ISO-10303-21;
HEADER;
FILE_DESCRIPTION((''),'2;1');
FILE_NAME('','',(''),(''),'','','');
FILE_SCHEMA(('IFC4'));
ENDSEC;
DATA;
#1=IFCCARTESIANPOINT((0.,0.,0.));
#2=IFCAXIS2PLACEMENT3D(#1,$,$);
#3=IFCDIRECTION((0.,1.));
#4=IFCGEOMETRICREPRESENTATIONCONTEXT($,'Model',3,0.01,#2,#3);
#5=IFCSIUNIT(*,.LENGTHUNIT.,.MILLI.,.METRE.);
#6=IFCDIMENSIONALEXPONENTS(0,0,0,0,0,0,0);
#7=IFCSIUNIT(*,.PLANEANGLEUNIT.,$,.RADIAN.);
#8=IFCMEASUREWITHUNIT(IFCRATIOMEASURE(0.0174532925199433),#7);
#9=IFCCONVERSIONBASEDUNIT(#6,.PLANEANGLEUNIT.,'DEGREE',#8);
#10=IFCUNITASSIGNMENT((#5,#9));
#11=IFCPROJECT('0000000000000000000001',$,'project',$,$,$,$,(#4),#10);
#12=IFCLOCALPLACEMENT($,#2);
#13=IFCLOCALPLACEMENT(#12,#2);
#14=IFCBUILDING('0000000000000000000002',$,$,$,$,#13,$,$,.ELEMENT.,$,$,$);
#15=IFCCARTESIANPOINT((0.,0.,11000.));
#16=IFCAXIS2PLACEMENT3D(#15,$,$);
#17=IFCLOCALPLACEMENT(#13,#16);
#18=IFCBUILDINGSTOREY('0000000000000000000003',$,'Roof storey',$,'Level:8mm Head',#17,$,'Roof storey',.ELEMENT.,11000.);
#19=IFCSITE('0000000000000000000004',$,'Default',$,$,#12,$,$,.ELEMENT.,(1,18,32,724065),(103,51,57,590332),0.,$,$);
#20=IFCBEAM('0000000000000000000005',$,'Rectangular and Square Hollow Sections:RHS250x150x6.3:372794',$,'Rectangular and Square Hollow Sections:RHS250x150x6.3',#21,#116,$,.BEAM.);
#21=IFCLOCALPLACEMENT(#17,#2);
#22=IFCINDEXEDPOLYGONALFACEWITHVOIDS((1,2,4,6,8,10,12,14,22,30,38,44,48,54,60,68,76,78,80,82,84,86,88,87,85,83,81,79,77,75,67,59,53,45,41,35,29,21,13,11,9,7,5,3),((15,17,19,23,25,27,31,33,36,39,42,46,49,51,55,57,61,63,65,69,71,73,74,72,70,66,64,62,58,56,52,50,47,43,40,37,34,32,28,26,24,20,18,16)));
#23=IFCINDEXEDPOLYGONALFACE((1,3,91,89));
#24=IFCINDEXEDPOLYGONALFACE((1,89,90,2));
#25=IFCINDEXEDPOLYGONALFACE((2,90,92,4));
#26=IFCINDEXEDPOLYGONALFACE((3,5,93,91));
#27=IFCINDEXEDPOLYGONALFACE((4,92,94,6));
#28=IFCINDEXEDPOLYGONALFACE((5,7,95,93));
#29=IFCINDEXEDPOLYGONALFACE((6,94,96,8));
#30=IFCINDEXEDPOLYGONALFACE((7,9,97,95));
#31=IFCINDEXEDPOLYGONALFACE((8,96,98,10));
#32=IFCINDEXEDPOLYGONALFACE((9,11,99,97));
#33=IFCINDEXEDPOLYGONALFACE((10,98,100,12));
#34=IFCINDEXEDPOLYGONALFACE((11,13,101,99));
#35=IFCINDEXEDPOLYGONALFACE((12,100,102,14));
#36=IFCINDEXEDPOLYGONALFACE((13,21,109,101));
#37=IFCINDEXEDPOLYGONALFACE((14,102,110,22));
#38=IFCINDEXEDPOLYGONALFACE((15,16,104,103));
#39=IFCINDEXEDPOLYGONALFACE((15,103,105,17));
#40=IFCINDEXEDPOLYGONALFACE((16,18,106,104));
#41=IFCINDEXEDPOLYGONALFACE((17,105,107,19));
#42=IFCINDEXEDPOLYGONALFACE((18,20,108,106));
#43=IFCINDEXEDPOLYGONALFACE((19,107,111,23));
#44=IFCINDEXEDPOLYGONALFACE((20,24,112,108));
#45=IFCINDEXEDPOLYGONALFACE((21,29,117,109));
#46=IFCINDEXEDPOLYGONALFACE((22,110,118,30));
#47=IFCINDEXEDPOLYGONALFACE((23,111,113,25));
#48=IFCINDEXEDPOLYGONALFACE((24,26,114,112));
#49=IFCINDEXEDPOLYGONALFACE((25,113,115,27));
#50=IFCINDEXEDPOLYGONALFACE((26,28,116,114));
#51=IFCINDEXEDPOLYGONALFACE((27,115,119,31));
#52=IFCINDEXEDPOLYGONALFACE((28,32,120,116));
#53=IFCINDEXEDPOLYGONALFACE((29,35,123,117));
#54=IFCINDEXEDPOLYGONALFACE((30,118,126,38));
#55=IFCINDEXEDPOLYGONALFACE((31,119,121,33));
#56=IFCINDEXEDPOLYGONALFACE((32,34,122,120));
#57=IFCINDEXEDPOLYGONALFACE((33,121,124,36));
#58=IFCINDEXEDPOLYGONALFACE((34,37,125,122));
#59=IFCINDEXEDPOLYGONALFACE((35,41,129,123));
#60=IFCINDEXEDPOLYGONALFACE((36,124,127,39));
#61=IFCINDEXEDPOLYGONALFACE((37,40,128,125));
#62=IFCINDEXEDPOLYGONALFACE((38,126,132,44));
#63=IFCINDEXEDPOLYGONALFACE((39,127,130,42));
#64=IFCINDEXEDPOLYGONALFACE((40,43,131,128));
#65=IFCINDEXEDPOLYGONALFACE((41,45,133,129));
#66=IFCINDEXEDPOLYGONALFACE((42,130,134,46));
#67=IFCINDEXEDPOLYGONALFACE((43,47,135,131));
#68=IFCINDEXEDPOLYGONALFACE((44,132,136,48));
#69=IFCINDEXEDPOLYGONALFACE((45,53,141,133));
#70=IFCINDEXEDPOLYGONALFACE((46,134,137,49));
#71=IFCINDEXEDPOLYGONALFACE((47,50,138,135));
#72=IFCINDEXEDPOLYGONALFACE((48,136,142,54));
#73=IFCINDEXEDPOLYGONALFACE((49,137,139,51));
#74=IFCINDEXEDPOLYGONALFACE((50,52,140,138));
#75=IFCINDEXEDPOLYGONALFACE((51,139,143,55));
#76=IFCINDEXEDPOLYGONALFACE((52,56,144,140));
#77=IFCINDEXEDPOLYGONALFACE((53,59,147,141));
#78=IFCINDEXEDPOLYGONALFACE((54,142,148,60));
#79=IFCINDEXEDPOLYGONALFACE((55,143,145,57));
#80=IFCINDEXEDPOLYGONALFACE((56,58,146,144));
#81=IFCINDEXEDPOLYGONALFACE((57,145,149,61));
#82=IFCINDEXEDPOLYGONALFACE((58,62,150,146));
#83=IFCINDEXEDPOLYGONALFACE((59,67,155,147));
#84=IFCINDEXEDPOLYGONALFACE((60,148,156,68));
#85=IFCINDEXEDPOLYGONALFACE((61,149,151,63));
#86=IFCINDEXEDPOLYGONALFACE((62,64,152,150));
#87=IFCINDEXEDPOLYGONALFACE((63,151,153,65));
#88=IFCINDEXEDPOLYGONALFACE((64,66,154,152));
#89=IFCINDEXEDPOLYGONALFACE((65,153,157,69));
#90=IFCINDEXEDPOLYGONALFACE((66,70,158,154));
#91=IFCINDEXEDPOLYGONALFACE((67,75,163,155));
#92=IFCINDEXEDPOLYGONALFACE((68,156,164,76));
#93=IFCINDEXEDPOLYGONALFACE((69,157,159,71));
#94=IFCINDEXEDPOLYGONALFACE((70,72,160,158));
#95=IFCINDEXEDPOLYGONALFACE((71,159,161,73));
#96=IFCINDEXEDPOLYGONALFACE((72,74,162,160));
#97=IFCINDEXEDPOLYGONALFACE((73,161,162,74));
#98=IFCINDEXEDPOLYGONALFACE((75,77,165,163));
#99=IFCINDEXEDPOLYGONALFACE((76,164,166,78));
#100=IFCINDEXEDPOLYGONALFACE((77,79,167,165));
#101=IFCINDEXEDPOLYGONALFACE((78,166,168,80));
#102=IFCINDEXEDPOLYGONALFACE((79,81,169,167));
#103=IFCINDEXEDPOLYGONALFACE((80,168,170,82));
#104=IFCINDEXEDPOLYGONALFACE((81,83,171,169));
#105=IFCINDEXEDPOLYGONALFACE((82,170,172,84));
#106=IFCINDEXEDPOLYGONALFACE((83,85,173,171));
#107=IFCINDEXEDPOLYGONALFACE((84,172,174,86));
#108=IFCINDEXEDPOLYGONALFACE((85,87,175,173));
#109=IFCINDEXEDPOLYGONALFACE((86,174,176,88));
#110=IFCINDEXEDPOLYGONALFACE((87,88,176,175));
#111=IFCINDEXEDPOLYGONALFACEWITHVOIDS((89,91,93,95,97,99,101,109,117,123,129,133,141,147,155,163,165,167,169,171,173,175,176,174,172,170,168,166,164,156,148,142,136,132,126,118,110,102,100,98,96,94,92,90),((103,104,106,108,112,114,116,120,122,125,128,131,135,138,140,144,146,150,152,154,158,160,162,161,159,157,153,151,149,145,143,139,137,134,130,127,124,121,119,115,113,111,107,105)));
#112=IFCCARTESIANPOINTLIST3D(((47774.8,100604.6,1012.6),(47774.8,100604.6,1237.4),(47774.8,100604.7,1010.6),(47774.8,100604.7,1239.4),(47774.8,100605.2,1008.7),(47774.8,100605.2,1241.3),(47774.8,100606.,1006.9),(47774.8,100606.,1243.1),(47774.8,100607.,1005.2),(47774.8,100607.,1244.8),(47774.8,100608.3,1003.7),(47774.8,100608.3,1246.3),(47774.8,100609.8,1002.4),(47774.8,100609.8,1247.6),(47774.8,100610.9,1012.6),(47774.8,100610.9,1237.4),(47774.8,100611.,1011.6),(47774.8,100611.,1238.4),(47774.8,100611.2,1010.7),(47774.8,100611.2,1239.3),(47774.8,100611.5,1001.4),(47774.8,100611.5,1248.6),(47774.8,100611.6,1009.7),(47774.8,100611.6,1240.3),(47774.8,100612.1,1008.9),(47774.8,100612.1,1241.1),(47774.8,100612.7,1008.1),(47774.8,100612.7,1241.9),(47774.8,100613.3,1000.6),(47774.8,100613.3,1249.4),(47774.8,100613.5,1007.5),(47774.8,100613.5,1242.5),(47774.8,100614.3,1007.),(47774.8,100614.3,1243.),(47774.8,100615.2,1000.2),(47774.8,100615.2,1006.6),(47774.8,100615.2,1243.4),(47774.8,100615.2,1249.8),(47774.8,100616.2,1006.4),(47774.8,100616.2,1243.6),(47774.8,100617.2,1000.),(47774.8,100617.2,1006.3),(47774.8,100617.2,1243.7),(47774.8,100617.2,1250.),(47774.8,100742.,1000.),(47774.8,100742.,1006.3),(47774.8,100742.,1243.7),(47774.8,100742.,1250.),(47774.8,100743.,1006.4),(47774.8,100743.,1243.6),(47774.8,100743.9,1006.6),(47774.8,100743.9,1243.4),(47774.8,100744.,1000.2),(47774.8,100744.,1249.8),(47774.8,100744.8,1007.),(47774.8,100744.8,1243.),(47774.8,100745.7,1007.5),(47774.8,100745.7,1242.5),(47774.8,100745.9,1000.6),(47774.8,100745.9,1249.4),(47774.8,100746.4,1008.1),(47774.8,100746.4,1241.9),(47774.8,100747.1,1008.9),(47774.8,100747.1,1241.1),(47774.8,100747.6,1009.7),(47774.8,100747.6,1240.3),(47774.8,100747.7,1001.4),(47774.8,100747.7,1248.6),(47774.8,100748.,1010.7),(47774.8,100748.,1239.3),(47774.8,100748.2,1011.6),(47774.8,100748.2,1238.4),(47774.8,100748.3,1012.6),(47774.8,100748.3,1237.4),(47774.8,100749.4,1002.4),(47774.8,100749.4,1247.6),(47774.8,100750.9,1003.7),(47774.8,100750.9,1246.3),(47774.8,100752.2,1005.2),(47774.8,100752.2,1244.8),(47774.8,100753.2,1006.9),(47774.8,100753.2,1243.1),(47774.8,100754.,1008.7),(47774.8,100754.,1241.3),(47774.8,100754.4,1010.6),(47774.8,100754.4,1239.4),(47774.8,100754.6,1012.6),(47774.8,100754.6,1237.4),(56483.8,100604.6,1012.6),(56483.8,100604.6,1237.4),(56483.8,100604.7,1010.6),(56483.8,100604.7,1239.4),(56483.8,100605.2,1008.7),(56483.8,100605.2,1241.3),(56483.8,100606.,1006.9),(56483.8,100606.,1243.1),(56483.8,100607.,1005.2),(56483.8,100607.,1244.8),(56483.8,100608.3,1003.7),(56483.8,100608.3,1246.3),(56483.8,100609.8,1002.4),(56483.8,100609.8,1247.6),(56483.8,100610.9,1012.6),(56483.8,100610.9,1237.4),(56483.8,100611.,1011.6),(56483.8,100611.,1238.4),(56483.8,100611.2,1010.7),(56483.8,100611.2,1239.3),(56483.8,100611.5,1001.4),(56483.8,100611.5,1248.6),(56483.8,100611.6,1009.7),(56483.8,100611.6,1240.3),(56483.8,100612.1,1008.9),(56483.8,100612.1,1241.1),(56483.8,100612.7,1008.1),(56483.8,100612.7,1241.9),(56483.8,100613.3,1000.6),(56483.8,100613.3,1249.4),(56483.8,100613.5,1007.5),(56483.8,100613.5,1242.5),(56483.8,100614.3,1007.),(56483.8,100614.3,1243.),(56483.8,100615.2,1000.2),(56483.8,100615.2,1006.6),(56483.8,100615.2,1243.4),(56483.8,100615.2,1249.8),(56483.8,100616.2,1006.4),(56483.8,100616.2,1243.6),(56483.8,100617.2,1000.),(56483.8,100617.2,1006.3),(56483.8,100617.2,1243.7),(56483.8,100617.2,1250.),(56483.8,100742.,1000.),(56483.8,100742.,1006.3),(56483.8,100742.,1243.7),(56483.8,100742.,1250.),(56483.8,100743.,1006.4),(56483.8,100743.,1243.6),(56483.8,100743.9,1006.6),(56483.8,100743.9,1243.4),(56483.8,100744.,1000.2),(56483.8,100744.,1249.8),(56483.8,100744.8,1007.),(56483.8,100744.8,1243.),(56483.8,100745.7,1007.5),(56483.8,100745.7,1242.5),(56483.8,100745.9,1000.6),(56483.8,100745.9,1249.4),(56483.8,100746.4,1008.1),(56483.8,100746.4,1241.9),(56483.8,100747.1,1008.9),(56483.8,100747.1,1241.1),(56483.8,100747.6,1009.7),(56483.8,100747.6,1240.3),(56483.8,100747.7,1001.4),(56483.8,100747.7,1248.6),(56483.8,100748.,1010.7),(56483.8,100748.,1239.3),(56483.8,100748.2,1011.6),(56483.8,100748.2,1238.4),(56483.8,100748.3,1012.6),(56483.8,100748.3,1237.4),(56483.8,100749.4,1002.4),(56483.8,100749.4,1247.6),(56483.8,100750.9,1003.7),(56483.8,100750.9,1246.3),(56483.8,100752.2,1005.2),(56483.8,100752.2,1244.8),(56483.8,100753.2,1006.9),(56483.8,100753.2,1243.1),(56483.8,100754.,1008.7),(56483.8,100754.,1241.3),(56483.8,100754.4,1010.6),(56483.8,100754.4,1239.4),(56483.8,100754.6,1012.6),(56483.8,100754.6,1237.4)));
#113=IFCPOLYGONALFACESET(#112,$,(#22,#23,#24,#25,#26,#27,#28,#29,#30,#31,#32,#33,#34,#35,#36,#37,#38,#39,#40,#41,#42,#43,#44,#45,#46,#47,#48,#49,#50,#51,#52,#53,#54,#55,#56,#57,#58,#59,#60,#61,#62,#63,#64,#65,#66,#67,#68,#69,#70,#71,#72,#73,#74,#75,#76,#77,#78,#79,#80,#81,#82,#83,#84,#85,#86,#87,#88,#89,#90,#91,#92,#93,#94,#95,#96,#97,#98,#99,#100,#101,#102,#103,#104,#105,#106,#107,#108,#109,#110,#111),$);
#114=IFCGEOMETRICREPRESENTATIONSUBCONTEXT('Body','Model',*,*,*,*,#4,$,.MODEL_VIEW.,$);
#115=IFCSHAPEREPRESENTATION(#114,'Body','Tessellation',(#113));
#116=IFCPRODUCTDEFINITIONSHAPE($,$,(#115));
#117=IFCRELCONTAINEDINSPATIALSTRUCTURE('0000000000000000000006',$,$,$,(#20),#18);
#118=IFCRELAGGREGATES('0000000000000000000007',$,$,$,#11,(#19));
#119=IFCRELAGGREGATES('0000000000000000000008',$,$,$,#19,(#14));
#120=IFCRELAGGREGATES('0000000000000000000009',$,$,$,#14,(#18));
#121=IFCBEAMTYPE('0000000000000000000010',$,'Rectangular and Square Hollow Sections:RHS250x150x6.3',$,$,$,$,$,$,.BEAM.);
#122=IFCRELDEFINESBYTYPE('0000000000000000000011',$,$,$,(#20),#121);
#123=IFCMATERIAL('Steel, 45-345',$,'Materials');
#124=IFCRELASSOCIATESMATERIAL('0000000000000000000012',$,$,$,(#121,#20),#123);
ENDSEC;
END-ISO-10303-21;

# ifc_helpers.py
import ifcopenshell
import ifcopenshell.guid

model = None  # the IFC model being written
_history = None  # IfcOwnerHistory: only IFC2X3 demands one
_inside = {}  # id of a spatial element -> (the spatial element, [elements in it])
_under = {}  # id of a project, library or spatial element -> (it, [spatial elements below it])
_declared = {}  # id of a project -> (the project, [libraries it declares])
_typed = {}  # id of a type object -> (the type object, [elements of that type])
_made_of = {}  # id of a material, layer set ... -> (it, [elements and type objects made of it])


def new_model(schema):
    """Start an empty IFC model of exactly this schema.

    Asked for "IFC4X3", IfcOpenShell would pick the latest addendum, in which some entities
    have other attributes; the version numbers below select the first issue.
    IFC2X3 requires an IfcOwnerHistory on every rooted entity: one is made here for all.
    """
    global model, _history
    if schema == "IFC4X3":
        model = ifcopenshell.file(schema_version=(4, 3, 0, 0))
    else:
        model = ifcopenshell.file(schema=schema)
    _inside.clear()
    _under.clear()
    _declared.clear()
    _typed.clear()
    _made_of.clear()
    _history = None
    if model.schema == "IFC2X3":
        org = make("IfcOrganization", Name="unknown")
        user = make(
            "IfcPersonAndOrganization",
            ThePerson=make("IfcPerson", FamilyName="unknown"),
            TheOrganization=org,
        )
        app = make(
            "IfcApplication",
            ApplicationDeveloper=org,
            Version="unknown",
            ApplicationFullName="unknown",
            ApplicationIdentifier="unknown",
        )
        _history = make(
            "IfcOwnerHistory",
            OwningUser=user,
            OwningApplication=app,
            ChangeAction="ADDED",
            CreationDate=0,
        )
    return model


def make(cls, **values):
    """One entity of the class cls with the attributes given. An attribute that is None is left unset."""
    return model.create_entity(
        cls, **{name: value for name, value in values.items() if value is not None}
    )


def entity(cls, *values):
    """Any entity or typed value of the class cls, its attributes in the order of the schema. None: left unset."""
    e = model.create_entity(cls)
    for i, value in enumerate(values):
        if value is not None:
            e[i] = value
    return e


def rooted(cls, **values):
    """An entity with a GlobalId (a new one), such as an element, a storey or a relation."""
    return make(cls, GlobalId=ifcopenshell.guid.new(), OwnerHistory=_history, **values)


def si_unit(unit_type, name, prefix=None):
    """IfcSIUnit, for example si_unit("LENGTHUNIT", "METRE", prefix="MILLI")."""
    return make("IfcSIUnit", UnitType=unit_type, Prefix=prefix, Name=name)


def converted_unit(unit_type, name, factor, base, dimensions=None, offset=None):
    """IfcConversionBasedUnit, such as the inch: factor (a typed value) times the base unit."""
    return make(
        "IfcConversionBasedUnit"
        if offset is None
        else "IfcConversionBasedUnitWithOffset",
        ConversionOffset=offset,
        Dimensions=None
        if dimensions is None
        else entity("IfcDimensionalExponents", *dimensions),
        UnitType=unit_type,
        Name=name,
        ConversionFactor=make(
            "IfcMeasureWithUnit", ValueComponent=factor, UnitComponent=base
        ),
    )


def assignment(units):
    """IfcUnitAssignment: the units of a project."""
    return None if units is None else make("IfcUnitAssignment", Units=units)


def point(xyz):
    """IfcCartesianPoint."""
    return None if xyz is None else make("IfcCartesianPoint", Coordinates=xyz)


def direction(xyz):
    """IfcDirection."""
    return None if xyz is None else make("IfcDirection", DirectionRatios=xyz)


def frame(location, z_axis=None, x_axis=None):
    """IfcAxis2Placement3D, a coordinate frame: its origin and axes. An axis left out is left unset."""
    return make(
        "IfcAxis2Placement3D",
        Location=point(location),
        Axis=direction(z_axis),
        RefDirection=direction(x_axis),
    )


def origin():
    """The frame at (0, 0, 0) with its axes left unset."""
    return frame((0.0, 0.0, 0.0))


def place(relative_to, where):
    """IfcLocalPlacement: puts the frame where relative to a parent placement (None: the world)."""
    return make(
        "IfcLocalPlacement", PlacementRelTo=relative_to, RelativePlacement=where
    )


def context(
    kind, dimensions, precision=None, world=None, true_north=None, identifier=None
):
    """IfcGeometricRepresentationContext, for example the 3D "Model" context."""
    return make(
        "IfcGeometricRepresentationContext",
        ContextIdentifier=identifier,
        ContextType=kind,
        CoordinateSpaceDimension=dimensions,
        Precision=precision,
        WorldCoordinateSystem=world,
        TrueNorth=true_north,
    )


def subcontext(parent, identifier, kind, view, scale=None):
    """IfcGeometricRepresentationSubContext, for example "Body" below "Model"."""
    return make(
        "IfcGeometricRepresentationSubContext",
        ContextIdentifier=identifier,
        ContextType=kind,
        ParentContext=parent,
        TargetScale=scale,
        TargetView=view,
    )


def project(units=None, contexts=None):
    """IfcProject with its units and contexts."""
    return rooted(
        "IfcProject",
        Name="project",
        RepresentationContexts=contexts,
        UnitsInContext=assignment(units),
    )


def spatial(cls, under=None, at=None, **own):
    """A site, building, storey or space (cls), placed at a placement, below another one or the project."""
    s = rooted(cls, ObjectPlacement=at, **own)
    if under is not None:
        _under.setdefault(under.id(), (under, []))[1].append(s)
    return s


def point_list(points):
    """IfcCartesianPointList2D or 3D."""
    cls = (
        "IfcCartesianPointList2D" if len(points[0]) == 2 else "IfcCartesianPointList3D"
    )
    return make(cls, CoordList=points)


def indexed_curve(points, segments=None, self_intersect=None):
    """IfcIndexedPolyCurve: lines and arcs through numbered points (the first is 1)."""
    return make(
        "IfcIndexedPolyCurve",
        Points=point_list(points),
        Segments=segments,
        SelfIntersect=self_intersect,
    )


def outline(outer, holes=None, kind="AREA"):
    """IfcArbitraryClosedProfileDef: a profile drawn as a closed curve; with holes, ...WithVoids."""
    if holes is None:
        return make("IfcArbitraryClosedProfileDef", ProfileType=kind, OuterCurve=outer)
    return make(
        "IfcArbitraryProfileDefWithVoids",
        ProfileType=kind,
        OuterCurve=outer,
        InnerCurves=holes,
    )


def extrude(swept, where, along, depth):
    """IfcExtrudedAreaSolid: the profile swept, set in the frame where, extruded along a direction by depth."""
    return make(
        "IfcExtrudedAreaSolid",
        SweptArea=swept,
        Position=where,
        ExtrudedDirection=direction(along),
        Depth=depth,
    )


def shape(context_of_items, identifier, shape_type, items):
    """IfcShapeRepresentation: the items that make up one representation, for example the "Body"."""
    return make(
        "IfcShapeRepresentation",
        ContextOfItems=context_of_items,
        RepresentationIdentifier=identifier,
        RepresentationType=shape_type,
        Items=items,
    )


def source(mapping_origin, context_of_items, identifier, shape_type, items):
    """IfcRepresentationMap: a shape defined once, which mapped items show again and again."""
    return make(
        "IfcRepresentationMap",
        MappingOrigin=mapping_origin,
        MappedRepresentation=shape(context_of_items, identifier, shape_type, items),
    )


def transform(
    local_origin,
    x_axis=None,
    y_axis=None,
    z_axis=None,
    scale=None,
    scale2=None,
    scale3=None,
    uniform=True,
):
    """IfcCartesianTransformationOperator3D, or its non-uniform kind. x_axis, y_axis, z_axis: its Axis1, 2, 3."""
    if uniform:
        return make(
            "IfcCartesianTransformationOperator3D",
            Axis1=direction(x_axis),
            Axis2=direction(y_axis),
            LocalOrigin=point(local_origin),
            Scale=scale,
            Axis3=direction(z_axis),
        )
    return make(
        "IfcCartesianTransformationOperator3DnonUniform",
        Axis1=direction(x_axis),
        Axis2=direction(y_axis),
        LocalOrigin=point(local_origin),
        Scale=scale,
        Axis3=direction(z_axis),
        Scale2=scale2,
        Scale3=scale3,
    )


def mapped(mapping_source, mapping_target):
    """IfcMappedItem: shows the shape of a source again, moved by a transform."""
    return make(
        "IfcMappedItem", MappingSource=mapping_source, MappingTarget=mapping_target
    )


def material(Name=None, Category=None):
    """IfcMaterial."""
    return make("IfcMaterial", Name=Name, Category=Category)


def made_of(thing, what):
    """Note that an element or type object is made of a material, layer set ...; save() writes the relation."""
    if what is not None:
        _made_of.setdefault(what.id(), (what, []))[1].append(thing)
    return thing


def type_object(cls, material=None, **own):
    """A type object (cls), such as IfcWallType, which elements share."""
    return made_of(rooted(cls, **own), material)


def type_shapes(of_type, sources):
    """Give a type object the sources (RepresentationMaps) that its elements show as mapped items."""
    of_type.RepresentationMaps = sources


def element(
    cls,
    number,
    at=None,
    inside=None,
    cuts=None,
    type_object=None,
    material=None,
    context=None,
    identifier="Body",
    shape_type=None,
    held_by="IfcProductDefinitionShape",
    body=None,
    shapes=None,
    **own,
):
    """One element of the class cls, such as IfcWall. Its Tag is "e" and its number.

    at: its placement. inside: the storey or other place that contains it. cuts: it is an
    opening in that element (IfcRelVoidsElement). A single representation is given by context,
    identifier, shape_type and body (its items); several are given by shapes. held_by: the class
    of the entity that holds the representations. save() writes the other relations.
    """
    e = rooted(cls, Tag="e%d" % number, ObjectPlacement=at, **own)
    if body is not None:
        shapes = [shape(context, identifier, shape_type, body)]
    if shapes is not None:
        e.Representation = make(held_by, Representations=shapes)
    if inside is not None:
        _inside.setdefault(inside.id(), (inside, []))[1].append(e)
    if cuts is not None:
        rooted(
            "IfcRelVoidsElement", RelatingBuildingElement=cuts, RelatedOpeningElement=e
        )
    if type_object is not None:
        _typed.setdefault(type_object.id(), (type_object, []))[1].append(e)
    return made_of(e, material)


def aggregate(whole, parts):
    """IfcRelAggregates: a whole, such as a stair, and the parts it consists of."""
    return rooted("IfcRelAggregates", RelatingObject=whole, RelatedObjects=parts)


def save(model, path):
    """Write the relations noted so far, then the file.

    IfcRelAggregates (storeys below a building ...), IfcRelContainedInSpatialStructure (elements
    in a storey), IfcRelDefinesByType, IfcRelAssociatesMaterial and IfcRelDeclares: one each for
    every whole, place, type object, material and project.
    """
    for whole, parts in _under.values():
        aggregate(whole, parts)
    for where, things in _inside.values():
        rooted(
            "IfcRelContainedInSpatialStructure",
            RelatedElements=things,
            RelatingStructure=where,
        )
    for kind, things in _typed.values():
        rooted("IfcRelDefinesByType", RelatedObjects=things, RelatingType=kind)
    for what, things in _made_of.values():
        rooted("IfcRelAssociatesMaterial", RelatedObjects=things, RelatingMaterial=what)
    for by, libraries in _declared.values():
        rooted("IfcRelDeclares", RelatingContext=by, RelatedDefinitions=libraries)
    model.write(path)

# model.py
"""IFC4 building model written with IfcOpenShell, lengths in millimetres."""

from ifc_helpers import new_model, entity, si_unit, converted_unit, direction, frame, origin, place, context, subcontext, project, spatial, indexed_curve, outline, extrude, source, transform, mapped, material, type_object, type_shapes, element, save


model = new_model("IFC4")

# Units and contexts
model_context = context("Model", 3, precision=0.01, world=origin(), true_north=direction((0.0, 1.0)))
body_context = subcontext(model_context, "Body", "Model", "MODEL_VIEW")
ifc_project = project(units=[si_unit("LENGTHUNIT", "METRE", prefix="MILLI"), converted_unit("PLANEANGLEUNIT", "DEGREE", entity("IfcRatioMeasure", 0.0174532925199433), si_unit("PLANEANGLEUNIT", "RADIAN"), dimensions=[0, 0, 0, 0, 0, 0, 0])], contexts=[model_context])

# Site, building, storey
site_placement = place(None, origin())
site = spatial("IfcSite", under=ifc_project, at=site_placement, Name="Default", CompositionType="ELEMENT", RefLatitude=(1, 18, 32, 724065), RefLongitude=(103, 51, 57, 590332), RefElevation=0.0)
building_placement = place(site_placement, origin())
building = spatial("IfcBuilding", under=site, at=building_placement, CompositionType="ELEMENT")
storey_placement = place(building_placement, frame((0.0, 0.0, 11000.0)))
storey = spatial("IfcBuildingStorey", under=building, at=storey_placement, Name="Roof storey", ObjectType="Level:8mm Head", LongName="Roof storey", CompositionType="ELEMENT", Elevation=11000.0)

# Shared definitions
ifc_material = material(Name="Steel, 45-345", Category="Materials")

# Beam
beam_type_1 = type_object("IfcBeamType", Name="Rectangular and Square Hollow Sections:RHS250x150x6.3", PredefinedType="BEAM", material=ifc_material)
shared_shape_1 = source(origin(), body_context, "Body", "SweptSolid", [
    extrude(outline(indexed_curve([(-75.0, -112.4), (-74.8, -114.4), (-74.4, -116.3), (-73.6, -118.1), (-72.6, -119.8), (-71.3, -121.3), (-69.8, -122.6), (-68.1, -123.6), (-66.3, -124.4), (-64.4, -124.8), (-62.4, -125.0), (62.4, -125.0), (64.4, -124.8), (66.3, -124.4), (68.1, -123.6), (69.8, -122.6), (71.3, -121.3), (72.6, -119.8), (73.6, -118.1), (74.4, -116.3), (74.8, -114.4), (75.0, -112.4), (75.0, 112.4), (74.8, 114.4), (74.4, 116.3), (73.6, 118.1), (72.6, 119.8), (71.3, 121.3), (69.8, 122.6), (68.1, 123.6), (66.3, 124.4), (64.4, 124.8), (62.4, 125.0), (-62.4, 125.0), (-64.4, 124.8), (-66.3, 124.4), (-68.1, 123.6), (-69.8, 122.6), (-71.3, 121.3), (-72.6, 119.8), (-73.6, 118.1), (-74.4, 116.3), (-74.8, 114.4), (-75.0, 112.4), (-75.0, -112.4)], self_intersect=False), holes=[indexed_curve([(62.4, -118.7), (-62.4, -118.7), (-63.4, -118.6), (-64.3, -118.4), (-65.3, -118.0), (-66.1, -117.5), (-66.9, -116.9), (-67.5, -116.1), (-68.0, -115.3), (-68.4, -114.3), (-68.6, -113.4), (-68.7, -112.4), (-68.7, 112.4), (-68.6, 113.4), (-68.4, 114.3), (-68.0, 115.3), (-67.5, 116.1), (-66.9, 116.9), (-66.1, 117.5), (-65.3, 118.0), (-64.3, 118.4), (-63.4, 118.6), (-62.4, 118.7), (62.4, 118.7), (63.4, 118.6), (64.3, 118.4), (65.3, 118.0), (66.1, 117.5), (66.9, 116.9), (67.5, 116.1), (68.0, 115.3), (68.4, 114.3), (68.6, 113.4), (68.7, 112.4), (68.7, -112.4), (68.6, -113.4), (68.4, -114.3), (68.0, -115.3), (67.5, -116.1), (66.9, -116.9), (66.1, -117.5), (65.3, -118.0), (64.3, -118.4), (63.4, -118.6), (62.4, -118.7)], self_intersect=False)]), frame((-4317.0, 0.0, 0.0), z_axis=(1.0, 0.0, 0.0), x_axis=(0.0, -1.0, 0.0)), (0.0, 0.0, 1.0), 8709.0),
])
type_shapes(beam_type_1, [shared_shape_1])
beam_1_placement = place(storey_placement, frame((52091.8, 100679.6, 1125.0)))
element("IfcBeam", 1, at=beam_1_placement, inside=storey, type_object=beam_type_1, material=ifc_material, Name="Rectangular and Square Hollow Sections:RHS250x150x6.3:372794", ObjectType="Rectangular and Square Hollow Sections:RHS250x150x6.3", PredefinedType="BEAM", context=body_context, shape_type="MappedRepresentation", body=[
    mapped(shared_shape_1, transform((0.0, 0.0, 0.0), scale=1.0)),
])

save(model, "model.ifc")
